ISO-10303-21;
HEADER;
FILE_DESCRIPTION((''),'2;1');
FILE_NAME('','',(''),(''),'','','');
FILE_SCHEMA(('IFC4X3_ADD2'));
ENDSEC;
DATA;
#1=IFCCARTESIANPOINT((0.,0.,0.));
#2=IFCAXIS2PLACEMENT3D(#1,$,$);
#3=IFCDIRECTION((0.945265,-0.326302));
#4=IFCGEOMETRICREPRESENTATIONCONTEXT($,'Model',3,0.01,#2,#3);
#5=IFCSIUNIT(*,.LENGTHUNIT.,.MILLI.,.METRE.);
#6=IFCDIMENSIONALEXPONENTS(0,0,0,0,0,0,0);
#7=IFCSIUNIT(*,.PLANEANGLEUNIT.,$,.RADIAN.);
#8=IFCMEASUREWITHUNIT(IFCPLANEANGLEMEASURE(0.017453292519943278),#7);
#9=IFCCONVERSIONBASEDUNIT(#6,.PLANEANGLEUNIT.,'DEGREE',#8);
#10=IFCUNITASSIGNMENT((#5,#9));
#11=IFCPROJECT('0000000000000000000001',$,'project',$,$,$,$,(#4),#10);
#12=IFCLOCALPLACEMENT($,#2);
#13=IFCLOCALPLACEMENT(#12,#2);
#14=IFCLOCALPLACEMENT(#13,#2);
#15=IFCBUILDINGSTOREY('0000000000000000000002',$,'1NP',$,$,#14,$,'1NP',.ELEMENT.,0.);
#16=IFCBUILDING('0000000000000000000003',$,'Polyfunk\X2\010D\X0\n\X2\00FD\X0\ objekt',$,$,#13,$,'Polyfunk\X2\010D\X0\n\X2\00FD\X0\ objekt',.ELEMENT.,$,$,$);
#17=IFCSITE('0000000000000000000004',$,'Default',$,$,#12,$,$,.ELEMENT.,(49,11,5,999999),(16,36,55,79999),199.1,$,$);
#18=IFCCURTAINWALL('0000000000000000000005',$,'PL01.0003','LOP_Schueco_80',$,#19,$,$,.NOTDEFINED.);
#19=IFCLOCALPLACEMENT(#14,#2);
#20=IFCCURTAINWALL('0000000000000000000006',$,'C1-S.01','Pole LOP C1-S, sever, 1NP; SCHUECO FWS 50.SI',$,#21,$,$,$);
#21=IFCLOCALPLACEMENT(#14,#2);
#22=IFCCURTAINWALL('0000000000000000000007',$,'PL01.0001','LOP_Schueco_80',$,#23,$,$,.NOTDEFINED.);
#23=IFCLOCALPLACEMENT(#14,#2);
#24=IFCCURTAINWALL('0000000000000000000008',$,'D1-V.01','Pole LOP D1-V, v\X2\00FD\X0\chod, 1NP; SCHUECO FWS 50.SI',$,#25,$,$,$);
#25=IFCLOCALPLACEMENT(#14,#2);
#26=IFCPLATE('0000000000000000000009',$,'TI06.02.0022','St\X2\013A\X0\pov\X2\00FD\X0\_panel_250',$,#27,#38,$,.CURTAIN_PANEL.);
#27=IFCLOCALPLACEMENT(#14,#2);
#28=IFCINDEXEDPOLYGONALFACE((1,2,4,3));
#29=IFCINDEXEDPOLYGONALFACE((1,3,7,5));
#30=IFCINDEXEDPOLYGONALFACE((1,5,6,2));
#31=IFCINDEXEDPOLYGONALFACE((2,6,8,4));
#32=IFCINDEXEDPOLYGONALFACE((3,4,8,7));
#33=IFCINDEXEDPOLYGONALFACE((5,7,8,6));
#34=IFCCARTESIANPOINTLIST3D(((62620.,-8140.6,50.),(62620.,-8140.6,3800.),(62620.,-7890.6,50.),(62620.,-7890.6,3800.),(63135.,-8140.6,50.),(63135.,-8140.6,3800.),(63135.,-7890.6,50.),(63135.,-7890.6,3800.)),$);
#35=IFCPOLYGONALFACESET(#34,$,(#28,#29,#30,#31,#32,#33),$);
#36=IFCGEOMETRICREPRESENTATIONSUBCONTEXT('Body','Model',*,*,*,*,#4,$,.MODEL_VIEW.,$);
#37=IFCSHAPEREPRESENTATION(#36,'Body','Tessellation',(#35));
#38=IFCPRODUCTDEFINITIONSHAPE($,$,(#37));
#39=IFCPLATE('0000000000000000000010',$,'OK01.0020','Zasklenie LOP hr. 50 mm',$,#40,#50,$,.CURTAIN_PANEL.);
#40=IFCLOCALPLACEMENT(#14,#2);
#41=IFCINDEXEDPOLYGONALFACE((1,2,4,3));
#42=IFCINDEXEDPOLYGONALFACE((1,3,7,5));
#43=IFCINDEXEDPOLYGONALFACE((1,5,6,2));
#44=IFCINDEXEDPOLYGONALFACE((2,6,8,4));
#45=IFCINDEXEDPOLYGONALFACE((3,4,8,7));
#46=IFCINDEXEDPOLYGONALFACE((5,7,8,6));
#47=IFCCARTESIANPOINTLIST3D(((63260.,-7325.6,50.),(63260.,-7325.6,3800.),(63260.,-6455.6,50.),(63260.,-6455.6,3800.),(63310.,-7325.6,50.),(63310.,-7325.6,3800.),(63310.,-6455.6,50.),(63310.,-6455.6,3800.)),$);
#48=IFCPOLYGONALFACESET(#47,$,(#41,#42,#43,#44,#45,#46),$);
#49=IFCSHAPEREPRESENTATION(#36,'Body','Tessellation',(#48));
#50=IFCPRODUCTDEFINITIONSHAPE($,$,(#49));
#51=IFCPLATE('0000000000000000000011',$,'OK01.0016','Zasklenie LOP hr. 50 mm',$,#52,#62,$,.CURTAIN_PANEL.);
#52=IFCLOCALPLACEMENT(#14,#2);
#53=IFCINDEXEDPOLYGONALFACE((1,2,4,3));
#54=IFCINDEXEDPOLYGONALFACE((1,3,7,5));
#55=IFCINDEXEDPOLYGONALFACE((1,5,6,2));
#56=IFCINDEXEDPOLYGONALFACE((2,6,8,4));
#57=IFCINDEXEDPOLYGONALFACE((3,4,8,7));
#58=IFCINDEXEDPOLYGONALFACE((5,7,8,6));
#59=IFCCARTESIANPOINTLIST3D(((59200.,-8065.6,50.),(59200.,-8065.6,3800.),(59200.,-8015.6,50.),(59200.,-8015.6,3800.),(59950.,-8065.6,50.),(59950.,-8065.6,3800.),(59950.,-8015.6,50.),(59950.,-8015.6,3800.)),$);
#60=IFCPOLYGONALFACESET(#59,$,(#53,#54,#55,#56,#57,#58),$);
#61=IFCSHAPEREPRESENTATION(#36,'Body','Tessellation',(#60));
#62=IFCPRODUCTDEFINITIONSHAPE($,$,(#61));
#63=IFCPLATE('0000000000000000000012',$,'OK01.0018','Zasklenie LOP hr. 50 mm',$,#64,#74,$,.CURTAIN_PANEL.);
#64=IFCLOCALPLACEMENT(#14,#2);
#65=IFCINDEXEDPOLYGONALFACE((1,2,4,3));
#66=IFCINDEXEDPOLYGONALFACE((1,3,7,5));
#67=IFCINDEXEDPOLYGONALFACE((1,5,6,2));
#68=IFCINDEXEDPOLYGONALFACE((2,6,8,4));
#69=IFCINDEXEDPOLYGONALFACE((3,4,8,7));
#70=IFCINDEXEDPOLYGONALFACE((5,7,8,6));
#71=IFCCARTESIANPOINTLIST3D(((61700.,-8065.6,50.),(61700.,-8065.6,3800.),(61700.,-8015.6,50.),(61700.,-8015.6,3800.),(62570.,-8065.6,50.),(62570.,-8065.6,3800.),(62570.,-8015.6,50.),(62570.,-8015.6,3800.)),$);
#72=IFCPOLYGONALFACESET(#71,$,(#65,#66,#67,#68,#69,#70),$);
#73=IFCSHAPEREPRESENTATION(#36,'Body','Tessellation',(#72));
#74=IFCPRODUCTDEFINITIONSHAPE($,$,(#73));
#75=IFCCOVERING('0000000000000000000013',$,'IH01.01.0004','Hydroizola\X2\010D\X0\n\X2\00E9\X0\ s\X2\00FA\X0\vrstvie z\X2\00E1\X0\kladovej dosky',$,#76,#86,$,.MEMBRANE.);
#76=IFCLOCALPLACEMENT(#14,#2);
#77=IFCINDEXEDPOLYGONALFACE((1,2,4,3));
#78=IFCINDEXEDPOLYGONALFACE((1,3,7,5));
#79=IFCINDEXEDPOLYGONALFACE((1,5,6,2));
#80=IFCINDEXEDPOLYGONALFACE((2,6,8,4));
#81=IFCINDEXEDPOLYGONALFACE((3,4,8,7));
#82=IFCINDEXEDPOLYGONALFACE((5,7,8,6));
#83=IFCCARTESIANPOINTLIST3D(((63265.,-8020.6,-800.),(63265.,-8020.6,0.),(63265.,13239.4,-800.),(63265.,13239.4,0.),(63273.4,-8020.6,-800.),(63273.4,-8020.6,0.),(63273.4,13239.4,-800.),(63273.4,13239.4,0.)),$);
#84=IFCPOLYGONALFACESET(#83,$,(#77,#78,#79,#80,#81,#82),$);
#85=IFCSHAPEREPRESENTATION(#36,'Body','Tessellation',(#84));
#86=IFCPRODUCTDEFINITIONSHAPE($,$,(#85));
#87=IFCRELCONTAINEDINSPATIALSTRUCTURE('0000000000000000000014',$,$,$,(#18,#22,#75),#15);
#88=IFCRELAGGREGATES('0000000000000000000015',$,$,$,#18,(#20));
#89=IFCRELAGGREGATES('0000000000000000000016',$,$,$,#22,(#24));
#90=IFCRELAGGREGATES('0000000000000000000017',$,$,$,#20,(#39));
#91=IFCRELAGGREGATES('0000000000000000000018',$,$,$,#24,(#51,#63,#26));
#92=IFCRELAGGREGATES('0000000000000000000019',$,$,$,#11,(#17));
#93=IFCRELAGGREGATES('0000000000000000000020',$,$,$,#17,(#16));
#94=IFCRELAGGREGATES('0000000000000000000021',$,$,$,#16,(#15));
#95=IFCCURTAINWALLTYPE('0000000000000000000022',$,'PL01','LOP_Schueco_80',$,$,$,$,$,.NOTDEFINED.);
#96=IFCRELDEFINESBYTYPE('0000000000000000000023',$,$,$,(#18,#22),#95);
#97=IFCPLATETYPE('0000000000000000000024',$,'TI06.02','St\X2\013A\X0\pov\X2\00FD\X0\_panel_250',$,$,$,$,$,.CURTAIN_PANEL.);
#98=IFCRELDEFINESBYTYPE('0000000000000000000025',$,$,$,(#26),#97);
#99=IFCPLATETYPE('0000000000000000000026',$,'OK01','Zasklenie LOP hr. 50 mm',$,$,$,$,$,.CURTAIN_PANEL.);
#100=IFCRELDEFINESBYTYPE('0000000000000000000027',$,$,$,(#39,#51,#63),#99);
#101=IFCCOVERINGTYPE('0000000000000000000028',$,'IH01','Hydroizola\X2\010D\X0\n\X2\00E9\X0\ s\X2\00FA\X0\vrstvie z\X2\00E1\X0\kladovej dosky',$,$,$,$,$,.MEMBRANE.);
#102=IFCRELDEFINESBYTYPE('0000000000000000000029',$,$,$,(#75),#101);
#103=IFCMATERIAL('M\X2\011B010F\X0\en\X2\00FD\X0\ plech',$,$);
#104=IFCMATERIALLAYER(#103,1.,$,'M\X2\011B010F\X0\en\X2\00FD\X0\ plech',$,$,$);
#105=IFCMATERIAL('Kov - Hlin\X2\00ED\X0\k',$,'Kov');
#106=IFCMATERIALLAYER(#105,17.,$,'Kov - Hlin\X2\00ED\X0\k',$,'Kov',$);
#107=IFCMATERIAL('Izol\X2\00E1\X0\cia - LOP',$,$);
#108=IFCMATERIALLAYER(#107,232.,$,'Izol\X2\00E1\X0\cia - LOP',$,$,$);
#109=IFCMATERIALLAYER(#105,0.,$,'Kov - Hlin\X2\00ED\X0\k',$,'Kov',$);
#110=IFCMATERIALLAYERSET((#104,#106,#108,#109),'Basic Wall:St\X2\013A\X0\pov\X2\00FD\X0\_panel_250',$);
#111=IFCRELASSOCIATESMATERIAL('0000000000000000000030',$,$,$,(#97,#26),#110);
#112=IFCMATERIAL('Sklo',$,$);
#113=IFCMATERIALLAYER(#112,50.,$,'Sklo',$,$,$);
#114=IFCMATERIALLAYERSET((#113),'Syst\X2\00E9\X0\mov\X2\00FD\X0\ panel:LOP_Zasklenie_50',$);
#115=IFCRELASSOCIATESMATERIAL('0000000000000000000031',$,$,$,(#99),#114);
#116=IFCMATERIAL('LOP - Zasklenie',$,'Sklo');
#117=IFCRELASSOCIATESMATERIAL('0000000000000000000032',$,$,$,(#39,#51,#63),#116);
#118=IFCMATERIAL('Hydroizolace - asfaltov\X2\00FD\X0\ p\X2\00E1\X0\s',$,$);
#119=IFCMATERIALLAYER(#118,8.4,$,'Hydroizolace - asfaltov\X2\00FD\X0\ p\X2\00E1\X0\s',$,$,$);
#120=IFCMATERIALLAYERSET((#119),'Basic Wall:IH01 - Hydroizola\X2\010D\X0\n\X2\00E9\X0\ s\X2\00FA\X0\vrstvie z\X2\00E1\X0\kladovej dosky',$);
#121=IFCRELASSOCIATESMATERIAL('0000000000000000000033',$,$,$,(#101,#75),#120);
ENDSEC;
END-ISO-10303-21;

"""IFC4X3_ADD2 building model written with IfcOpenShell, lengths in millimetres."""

from ifc_helpers import new_model, entity, si_unit, converted_unit, direction, frame, frame_2d, origin, origin_2d_with_axis, place, context, subcontext, project, spatial, rectangle, extrude, source, transform, mapped, material, layer, layer_set, layer_usage, type_object, type_shapes, element, aggregate, save


model = new_model("IFC4X3_ADD2")

# Units and contexts
model_context = context("Model", 3, precision=0.01, world=origin(), true_north=direction((0.945265, -0.326302)))
body_context = subcontext(model_context, "Body", "Model", "MODEL_VIEW")
ifc_project = project(units=[si_unit("LENGTHUNIT", "METRE", prefix="MILLI"), converted_unit("PLANEANGLEUNIT", "DEGREE", entity("IfcPlaneAngleMeasure", 0.017453292519943278), si_unit("PLANEANGLEUNIT", "RADIAN"), dimensions=[0, 0, 0, 0, 0, 0, 0])], contexts=[model_context])

# Site, building, storey
site_placement = place(None, origin())
site = spatial("IfcSite", under=ifc_project, at=site_placement, Name="Default", CompositionType="ELEMENT", RefLatitude=(49, 11, 5, 999999), RefLongitude=(16, 36, 55, 79999), RefElevation=199.1)
building_placement = place(site_placement, origin())
building = spatial("IfcBuilding", under=site, at=building_placement, Name="Polyfunkčný objekt", LongName="Polyfunkčný objekt", CompositionType="ELEMENT")
storey_placement = place(building_placement, origin())
storey = spatial("IfcBuildingStorey", under=building, at=storey_placement, Name="1NP", LongName="1NP", CompositionType="ELEMENT", Elevation=0.0)

# Curtain walls
curtain_wall_type = type_object("IfcCurtainWallType", Name="PL01", Description="LOP_Schueco_80", PredefinedType="NOTDEFINED")
curtain_wall_1_placement = place(storey_placement, origin())
curtain_wall_1 = element("IfcCurtainWall", 1, at=curtain_wall_1_placement, inside=storey, type_object=curtain_wall_type, Name="PL01.0003", Description="LOP_Schueco_80", PredefinedType="NOTDEFINED")
curtain_wall_2 = element("IfcCurtainWall", 2, Name="C1-S.01", Description="Pole LOP C1-S, sever, 1NP; SCHUECO FWS 50.SI")
aggregate(curtain_wall_1, [curtain_wall_2])
curtain_wall_3_placement = place(storey_placement, origin())
curtain_wall_3 = element("IfcCurtainWall", 3, at=curtain_wall_3_placement, inside=storey, type_object=curtain_wall_type, Name="PL01.0001", Description="LOP_Schueco_80", PredefinedType="NOTDEFINED")
curtain_wall_4 = element("IfcCurtainWall", 4, Name="D1-V.01", Description="Pole LOP D1-V, východ, 1NP; SCHUECO FWS 50.SI")
aggregate(curtain_wall_3, [curtain_wall_4])

# Plates
ifc_material_1 = material(Name="Měďený plech")
ifc_layer_1 = layer(ifc_material_1, 1.0, Name="Měďený plech")
ifc_material_2 = material(Name="Kov - Hliník", Category="Kov")
ifc_layer_2 = layer(ifc_material_2, 17.0, Name="Kov - Hliník", Category="Kov")
ifc_material_3 = material(Name="Izolácia - LOP")
ifc_layer_3 = layer(ifc_material_3, 232.0, Name="Izolácia - LOP")
ifc_layer_4 = layer(ifc_material_2, 0.0, Name="Kov - Hliník", Category="Kov")
ifc_layer_set_1 = layer_set([ifc_layer_1, ifc_layer_2, ifc_layer_3, ifc_layer_4], Name="Basic Wall:Stĺpový_panel_250")
plate_type_1 = type_object("IfcPlateType", Name="TI06.02", Description="Stĺpový_panel_250", PredefinedType="CURTAIN_PANEL", material=ifc_layer_set_1)
ifc_layer_usage_1 = layer_usage(ifc_layer_set_1, "AXIS2", "POSITIVE", -125.0)
plate_1_placement = place(storey_placement, frame((62620.0, -8015.6, 50.0)))
plate_1 = element("IfcPlate", 5, at=plate_1_placement, type_object=plate_type_1, material=ifc_layer_usage_1, Name="TI06.02.0022", Description="Stĺpový_panel_250", PredefinedType="CURTAIN_PANEL", context=body_context, shape_type="SweptSolid", body=[
    extrude(rectangle(XDim=250.0, YDim=515.0, at=origin_2d_with_axis()), frame((257.5, 0.0, 0.0), z_axis=(0.0, 0.0, 1.0), x_axis=(0.0, 1.0, 0.0)), (0.0, 0.0, 1.0), 3750.0),
])
ifc_material_4 = material(Name="LOP - Zasklenie", Category="Sklo")
ifc_material_5 = material(Name="Sklo")
ifc_layer_5 = layer(ifc_material_5, 50.0, Name="Sklo")
ifc_layer_set_2 = layer_set([ifc_layer_5], Name="Systémový panel:LOP_Zasklenie_50")
plate_type_2 = type_object("IfcPlateType", Name="OK01", Description="Zasklenie LOP hr. 50 mm", PredefinedType="CURTAIN_PANEL", material=ifc_layer_set_2)
shared_shape_1 = source(origin(), body_context, "Body", "SweptSolid", [
    extrude(rectangle(XDim=3750.0, YDim=870.0, at=frame_2d((-141.7, 0.0), x_axis=(1.0, 0.0))), frame((0.0, 0.0, 2016.7), z_axis=(0.0, 1.0, 0.0), x_axis=(0.0, 0.0, 1.0)), (0.0, 0.0, 1.0), 50.0),
])
plate_2_placement = place(curtain_wall_1_placement, frame((63260.0, -6890.6, 50.0), z_axis=(0.0, 0.0, 1.0), x_axis=(0.0, -1.0, 0.0)))
plate_2 = element("IfcPlate", 6, at=plate_2_placement, type_object=plate_type_2, material=ifc_material_4, Name="OK01.0020", Description="Zasklenie LOP hr. 50 mm", PredefinedType="CURTAIN_PANEL", context=body_context, shape_type="MappedRepresentation", body=[
    mapped(shared_shape_1, transform((0.0, 0.0, 0.0), scale=1.0)),
])
aggregate(curtain_wall_2, [plate_2])
shared_shape_2 = source(origin(), body_context, "Body", "SweptSolid", [
    extrude(rectangle(XDim=3750.0, YDim=750.0, at=frame_2d((-331.2, 0.0), x_axis=(1.0, 0.0))), frame((0.0, -50.0, 2206.2), z_axis=(0.0, 1.0, 0.0), x_axis=(0.0, 0.0, 1.0)), (0.0, 0.0, 1.0), 50.0),
])
plate_3_placement = place(curtain_wall_3_placement, frame((59575.0, -8015.6, 50.0)))
plate_3 = element("IfcPlate", 7, at=plate_3_placement, type_object=plate_type_2, material=ifc_material_4, Name="OK01.0016", Description="Zasklenie LOP hr. 50 mm", PredefinedType="CURTAIN_PANEL", context=body_context, shape_type="MappedRepresentation", body=[
    mapped(shared_shape_2, transform((0.0, 0.0, 0.0), scale=1.0)),
])
shared_shape_3 = source(origin(), body_context, "Body", "SweptSolid", [
    extrude(rectangle(XDim=3750.0, YDim=870.0, at=frame_2d((-331.2, 0.0), x_axis=(1.0, 0.0))), frame((0.0, -50.0, 2206.2), z_axis=(0.0, 1.0, 0.0), x_axis=(0.0, 0.0, 1.0)), (0.0, 0.0, 1.0), 50.0),
])
type_shapes(plate_type_2, [shared_shape_1, shared_shape_2, shared_shape_3])
plate_4_placement = place(curtain_wall_3_placement, frame((62135.0, -8015.6, 50.0)))
plate_4 = element("IfcPlate", 8, at=plate_4_placement, type_object=plate_type_2, material=ifc_material_4, Name="OK01.0018", Description="Zasklenie LOP hr. 50 mm", PredefinedType="CURTAIN_PANEL", context=body_context, shape_type="MappedRepresentation", body=[
    mapped(shared_shape_3, transform((0.0, 0.0, 0.0), scale=1.0)),
])
aggregate(curtain_wall_4, [plate_3, plate_4, plate_1])

# Covering
ifc_material_6 = material(Name="Hydroizolace - asfaltový pás")
ifc_layer_6 = layer(ifc_material_6, 8.4, Name="Hydroizolace - asfaltový pás")
ifc_layer_set_3 = layer_set([ifc_layer_6], Name="Basic Wall:IH01 - Hydroizolačné súvrstvie základovej dosky")
covering_type = type_object("IfcCoveringType", Name="IH01", Description="Hydroizolačné súvrstvie základovej dosky", PredefinedType="MEMBRANE", material=ifc_layer_set_3)
covering_placement = place(storey_placement, frame((63269.2, -8020.6, -800.0), z_axis=(0.0, 0.0, 1.0), x_axis=(0.0, 1.0, 0.0)))
element("IfcCovering", 9, at=covering_placement, inside=storey, type_object=covering_type, material=ifc_layer_set_3, Name="IH01.01.0004", Description="Hydroizolačné súvrstvie základovej dosky", PredefinedType="MEMBRANE", context=body_context, shape_type="SweptSolid", body=[
    extrude(rectangle(XDim=21260.0, YDim=8.4, at=frame_2d((10630.0, 0.0), x_axis=(-1.0, 0.0))), origin(), (0.0, 0.0, 1.0), 800.0),
])

save(model, "model.ifc")
